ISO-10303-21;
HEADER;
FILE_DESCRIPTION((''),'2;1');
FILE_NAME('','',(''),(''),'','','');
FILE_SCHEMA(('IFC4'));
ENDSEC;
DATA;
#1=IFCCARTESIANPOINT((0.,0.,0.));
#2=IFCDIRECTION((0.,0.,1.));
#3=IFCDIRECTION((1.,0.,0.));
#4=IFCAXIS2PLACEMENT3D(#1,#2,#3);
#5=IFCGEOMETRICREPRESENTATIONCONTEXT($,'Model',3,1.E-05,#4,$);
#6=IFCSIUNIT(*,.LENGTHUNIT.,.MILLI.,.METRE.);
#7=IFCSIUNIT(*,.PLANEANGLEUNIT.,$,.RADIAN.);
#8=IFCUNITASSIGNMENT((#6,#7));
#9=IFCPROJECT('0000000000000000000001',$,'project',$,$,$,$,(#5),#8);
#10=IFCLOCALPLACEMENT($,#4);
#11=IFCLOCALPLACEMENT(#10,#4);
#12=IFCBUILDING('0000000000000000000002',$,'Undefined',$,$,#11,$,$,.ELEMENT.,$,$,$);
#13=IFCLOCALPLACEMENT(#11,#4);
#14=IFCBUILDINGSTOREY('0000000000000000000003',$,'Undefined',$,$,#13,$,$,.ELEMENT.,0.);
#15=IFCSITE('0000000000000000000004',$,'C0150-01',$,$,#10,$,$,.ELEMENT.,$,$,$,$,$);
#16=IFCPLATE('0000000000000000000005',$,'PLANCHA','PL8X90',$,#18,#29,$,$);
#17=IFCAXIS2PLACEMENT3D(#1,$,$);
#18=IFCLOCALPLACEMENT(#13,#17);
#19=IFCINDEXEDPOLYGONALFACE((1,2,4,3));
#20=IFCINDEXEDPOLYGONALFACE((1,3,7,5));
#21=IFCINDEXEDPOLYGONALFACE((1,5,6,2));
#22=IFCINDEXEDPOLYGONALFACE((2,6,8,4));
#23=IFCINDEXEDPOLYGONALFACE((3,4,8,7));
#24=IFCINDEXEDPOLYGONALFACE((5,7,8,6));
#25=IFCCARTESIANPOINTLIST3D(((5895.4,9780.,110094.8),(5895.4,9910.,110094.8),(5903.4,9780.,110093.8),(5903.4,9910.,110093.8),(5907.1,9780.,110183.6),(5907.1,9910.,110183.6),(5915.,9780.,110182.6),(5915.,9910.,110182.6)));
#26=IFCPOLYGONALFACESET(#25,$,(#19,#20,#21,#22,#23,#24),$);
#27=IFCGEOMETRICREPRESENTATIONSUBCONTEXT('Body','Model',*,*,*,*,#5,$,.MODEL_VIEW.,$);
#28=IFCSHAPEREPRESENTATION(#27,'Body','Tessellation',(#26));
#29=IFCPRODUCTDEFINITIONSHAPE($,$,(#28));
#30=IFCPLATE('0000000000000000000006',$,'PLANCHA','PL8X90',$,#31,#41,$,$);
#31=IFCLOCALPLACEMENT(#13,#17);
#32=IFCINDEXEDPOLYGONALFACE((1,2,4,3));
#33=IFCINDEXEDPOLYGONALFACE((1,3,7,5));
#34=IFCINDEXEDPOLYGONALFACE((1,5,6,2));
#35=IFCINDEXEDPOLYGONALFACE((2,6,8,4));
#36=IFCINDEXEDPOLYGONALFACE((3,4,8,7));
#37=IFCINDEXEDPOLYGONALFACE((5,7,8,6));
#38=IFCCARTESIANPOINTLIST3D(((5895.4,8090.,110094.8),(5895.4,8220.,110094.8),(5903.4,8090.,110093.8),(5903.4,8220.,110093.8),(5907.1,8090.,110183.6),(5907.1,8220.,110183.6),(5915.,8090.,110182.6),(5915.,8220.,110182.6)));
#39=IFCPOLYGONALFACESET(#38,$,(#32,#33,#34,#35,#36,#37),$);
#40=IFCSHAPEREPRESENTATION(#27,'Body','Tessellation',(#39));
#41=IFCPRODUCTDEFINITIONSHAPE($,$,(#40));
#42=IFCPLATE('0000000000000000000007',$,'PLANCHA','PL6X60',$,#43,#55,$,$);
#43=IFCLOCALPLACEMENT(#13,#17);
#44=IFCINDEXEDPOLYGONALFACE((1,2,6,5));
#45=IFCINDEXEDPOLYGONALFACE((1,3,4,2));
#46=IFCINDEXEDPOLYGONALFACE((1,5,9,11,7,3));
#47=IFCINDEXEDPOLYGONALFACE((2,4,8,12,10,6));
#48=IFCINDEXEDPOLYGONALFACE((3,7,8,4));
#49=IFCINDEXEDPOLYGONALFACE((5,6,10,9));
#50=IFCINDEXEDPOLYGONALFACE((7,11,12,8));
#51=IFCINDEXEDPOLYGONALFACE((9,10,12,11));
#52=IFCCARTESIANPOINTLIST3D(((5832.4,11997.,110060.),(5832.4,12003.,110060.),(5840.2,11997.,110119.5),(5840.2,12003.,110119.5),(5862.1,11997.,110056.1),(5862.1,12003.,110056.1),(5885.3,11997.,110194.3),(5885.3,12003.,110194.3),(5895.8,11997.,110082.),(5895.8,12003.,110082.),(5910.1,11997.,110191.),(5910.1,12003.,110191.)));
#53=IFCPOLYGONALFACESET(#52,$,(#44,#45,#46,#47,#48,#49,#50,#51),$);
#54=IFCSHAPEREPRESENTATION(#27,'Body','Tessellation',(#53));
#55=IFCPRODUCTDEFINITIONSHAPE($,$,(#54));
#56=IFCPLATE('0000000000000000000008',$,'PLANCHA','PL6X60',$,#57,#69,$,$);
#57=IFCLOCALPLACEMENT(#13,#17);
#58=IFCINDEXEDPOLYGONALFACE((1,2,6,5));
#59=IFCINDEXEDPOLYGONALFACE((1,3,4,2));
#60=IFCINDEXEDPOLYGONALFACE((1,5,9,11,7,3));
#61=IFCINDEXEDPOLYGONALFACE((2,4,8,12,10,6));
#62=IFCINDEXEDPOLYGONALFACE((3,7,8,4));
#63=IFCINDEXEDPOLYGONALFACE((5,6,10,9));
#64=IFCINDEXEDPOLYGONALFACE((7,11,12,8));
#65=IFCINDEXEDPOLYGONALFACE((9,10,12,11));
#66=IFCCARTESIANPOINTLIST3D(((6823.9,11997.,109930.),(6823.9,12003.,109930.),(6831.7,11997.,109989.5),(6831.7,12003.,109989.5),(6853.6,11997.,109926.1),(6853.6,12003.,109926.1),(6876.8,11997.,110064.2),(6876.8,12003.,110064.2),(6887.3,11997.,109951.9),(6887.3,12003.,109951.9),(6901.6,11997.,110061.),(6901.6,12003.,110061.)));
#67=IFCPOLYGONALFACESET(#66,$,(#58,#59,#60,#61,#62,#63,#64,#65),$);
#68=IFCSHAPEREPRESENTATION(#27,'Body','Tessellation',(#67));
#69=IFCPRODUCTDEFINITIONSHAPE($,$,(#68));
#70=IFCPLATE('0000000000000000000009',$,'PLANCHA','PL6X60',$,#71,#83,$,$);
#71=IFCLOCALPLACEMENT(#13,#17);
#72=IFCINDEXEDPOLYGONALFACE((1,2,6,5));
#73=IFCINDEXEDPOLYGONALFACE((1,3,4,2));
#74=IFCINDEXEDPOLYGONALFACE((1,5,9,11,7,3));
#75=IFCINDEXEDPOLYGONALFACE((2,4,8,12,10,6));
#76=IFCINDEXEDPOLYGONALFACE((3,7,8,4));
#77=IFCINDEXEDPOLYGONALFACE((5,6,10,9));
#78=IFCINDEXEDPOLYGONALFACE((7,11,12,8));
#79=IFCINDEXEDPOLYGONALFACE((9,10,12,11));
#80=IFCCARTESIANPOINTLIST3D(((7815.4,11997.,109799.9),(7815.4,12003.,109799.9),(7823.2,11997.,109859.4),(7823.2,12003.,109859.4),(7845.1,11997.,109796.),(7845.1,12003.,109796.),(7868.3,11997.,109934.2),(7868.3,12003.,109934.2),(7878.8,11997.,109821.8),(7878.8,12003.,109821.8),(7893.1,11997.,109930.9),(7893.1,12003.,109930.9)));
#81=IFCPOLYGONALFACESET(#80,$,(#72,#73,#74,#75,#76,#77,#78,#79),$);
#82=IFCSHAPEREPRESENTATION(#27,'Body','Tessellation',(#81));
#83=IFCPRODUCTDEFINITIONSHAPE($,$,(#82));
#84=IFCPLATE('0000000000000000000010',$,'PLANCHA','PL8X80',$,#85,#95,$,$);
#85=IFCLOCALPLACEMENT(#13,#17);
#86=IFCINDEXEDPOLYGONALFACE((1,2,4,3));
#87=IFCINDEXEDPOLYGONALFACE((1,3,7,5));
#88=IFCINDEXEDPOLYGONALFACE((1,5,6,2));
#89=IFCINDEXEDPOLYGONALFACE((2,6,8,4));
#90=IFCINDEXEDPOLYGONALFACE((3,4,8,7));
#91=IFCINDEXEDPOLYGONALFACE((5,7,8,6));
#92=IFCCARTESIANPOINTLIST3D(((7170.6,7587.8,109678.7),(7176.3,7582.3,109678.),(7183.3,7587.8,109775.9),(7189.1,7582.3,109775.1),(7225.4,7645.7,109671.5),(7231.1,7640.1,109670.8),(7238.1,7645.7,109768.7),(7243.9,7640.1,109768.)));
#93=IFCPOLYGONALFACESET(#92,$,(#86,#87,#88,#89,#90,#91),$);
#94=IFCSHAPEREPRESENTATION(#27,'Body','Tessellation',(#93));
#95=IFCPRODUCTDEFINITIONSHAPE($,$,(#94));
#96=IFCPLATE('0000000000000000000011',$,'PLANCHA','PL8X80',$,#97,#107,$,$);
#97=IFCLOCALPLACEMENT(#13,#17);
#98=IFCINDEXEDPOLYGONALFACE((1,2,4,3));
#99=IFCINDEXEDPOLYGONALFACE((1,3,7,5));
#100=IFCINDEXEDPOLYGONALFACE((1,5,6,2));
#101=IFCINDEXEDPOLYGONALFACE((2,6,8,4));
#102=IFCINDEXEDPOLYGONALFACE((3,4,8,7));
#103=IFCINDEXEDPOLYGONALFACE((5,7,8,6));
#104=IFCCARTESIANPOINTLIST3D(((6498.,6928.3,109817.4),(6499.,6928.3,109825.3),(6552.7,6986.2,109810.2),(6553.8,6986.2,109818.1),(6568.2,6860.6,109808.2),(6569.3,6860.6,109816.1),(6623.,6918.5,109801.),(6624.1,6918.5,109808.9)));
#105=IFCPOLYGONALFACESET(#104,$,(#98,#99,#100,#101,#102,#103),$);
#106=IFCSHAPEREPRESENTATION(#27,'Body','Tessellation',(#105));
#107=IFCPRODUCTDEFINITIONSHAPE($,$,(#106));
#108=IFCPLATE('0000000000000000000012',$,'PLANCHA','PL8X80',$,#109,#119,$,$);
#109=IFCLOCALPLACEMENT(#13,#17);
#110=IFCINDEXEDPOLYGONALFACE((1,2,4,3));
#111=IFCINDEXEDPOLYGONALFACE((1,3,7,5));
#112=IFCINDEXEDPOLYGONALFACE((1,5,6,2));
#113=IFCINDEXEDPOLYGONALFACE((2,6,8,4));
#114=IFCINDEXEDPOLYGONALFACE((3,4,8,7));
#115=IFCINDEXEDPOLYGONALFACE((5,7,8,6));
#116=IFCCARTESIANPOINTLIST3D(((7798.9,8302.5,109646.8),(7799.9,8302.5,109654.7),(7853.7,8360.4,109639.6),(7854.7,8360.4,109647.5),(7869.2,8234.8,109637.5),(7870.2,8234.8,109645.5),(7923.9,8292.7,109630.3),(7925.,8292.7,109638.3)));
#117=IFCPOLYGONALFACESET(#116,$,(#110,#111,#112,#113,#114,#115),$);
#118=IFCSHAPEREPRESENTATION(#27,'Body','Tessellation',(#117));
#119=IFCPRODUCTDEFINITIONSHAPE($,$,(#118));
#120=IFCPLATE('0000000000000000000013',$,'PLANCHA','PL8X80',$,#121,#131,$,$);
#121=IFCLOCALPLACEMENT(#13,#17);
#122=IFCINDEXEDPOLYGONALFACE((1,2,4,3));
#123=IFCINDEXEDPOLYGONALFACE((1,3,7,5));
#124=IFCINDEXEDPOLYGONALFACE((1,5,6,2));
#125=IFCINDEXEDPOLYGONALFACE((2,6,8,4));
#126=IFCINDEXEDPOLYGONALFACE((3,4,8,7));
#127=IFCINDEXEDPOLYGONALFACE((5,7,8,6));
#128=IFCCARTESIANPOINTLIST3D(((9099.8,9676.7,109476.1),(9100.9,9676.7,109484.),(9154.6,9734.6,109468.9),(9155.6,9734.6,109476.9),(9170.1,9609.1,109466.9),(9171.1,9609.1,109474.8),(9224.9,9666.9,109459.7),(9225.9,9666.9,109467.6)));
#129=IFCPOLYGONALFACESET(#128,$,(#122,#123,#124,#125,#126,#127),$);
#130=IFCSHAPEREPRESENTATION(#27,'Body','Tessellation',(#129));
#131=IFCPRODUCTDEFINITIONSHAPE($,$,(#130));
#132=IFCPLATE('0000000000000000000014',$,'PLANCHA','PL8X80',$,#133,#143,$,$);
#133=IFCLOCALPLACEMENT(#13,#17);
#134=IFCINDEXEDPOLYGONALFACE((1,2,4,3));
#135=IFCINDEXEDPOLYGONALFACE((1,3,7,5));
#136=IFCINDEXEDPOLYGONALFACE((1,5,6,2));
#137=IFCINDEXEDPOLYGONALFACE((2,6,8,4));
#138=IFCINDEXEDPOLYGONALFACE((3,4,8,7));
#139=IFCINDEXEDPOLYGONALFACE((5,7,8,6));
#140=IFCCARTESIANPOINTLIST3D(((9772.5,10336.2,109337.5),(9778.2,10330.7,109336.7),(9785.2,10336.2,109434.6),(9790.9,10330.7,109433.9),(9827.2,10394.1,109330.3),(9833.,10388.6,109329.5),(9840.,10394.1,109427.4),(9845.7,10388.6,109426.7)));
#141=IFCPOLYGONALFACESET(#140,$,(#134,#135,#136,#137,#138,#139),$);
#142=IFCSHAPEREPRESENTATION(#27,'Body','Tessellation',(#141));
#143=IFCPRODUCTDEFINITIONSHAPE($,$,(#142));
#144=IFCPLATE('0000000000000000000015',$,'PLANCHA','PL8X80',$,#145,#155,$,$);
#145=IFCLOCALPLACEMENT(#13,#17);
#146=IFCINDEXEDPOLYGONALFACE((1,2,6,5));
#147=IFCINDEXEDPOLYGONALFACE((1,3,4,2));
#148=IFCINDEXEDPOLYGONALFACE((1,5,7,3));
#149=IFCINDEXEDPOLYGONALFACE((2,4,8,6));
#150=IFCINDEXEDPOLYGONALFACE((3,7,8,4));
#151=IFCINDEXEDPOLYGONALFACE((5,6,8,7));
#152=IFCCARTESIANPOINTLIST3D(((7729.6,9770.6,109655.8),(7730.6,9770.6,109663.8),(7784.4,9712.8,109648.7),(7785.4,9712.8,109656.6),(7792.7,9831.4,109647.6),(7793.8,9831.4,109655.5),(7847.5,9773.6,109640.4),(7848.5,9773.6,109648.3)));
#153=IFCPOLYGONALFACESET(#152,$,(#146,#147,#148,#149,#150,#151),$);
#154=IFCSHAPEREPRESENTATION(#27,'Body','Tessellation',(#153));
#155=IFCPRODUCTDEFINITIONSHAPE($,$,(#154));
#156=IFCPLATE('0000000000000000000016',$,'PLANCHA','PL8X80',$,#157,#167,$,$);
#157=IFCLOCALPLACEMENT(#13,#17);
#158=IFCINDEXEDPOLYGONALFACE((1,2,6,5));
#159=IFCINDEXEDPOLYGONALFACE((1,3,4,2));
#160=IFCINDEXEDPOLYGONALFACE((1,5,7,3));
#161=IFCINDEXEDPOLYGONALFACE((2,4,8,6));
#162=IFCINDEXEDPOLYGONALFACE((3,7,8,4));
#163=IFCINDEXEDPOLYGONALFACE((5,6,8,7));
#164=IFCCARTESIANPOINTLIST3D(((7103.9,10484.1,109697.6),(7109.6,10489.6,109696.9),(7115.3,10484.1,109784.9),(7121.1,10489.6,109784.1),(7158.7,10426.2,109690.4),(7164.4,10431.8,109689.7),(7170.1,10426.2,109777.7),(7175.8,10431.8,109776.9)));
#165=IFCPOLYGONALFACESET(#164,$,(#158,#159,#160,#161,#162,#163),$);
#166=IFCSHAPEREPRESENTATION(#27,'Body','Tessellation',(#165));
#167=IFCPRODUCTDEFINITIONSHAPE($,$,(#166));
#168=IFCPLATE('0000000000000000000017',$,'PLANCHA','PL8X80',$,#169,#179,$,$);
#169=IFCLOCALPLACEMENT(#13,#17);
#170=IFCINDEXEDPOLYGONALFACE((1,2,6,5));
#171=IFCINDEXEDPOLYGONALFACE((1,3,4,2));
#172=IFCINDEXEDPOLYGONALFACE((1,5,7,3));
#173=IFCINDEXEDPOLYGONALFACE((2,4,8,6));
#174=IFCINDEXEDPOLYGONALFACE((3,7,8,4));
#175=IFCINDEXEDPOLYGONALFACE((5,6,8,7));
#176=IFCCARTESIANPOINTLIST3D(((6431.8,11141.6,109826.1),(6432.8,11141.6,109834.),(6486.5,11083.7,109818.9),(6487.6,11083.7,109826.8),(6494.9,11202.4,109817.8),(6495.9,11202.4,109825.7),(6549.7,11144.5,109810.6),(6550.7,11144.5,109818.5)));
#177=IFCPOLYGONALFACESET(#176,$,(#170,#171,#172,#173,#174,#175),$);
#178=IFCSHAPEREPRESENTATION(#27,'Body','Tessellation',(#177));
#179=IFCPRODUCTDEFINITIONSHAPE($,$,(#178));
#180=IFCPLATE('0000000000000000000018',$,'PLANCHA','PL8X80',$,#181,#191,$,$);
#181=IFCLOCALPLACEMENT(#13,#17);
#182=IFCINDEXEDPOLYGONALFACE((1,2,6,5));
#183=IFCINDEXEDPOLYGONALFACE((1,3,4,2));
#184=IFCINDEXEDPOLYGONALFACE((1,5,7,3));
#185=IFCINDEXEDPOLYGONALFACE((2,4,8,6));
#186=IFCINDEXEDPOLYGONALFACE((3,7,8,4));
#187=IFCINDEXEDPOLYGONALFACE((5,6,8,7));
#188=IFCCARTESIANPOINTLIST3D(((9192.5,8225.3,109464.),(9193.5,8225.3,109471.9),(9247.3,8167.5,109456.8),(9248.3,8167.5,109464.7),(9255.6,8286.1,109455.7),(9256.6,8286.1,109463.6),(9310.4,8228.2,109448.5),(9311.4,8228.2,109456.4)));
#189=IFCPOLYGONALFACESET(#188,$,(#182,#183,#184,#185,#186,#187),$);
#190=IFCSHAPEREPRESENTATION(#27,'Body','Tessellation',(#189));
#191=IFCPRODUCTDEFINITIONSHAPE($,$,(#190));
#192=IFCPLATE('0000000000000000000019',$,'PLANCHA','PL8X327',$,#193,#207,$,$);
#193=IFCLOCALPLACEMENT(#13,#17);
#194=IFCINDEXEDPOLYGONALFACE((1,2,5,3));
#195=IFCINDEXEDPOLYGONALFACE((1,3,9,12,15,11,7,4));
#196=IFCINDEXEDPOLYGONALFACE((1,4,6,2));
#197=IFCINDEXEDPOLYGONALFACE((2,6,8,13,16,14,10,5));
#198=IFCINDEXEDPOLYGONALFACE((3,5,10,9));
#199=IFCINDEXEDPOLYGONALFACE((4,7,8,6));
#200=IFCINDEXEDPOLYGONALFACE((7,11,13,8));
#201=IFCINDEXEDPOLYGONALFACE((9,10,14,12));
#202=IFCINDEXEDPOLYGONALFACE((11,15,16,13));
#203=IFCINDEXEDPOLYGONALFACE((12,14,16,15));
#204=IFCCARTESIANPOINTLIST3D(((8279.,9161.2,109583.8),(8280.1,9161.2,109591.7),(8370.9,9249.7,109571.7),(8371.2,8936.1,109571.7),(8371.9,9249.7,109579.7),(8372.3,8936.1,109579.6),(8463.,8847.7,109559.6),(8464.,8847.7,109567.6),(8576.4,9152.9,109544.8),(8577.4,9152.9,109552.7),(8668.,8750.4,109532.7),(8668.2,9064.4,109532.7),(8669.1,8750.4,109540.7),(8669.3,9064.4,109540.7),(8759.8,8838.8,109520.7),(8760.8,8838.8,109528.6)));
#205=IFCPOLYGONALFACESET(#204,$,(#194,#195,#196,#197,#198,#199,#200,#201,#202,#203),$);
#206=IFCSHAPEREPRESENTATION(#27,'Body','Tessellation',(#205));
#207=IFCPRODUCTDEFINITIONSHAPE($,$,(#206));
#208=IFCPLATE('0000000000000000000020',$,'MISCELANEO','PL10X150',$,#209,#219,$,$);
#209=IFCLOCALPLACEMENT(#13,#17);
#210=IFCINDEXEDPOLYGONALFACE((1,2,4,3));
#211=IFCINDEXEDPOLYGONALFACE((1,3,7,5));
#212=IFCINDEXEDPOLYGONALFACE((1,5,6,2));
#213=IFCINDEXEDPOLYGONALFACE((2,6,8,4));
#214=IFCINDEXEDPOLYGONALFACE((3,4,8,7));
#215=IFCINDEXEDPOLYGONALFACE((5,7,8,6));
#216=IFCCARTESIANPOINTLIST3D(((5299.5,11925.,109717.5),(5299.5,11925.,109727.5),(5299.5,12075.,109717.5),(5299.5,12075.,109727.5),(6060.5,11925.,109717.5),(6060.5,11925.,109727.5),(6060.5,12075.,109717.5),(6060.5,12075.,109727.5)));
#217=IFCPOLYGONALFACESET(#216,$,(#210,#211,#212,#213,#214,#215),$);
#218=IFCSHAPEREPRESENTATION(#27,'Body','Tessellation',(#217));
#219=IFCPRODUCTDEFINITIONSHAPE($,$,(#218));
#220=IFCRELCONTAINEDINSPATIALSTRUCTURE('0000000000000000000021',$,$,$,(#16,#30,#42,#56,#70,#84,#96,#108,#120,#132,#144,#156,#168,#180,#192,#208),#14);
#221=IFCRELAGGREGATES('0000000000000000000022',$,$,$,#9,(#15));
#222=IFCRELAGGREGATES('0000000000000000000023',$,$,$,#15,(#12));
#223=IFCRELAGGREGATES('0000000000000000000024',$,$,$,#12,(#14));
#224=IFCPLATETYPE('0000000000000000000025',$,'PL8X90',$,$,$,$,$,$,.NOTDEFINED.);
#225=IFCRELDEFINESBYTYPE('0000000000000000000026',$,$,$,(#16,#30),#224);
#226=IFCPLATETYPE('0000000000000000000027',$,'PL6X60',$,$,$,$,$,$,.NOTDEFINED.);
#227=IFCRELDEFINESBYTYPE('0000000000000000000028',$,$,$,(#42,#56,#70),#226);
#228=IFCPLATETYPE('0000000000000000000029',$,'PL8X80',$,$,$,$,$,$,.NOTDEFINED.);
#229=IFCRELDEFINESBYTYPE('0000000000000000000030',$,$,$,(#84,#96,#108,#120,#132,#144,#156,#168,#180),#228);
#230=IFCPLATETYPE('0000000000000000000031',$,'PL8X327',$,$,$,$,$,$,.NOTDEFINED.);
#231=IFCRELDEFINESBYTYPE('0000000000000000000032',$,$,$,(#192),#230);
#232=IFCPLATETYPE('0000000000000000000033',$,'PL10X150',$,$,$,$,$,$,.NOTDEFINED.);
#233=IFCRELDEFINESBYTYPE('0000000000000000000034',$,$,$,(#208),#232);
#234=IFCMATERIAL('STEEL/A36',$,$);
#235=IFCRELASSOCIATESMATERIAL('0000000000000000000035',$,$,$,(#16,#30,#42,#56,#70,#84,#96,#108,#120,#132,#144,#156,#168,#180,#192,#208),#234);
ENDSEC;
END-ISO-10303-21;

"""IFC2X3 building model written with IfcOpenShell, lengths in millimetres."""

from ifc_helpers import new_model, si_unit, frame, origin_with_axes, place, context, subcontext, project, spatial, polyline, outline, extrude, material, type_object, element, save


model = new_model("IFC2X3")

# Units and contexts
model_context = context("Model", 3, precision=1e-05, world=origin_with_axes())
body_context = subcontext(model_context, "Body", "Model", "MODEL_VIEW")
ifc_project = project(units=[si_unit("LENGTHUNIT", "METRE", prefix="MILLI"), si_unit("PLANEANGLEUNIT", "RADIAN")], contexts=[model_context])

# Site, building, storey
site_placement = place(None, origin_with_axes())
site = spatial("IfcSite", under=ifc_project, at=site_placement, Name="C0150-01", CompositionType="ELEMENT")
building_placement = place(site_placement, origin_with_axes())
building = spatial("IfcBuilding", under=site, at=building_placement, Name="Undefined", CompositionType="ELEMENT")
storey_placement = place(building_placement, origin_with_axes())
storey = spatial("IfcBuildingStorey", under=building, at=storey_placement, Name="Undefined", CompositionType="ELEMENT", Elevation=0.0)

# Shared definitions
ifc_material_1 = material(Name="STEEL/A36")

# Plates
plate_type_1 = type_object("IfcPlateType", Name="PL8X90", PredefinedType="NOTDEFINED")
for number, where, z_axis, x_axis, name in (
    (1, (5911.0, 9910.0, 110183.1), (0.991507, 0.0, -0.130054), (0.0, -1.0, 0.0), "PLANCHA"),
    (2, (5911.0, 8090.0, 110183.1), (-0.991507, 0.0, 0.130054), (0.0, 1.0, 0.0), "PLANCHA"),
):
    element("IfcPlate", number, at=place(storey_placement, frame(where, z_axis=z_axis, x_axis=x_axis)), inside=storey, type_object=plate_type_1, material=ifc_material_1, Name=name, Description="PL8X90", context=body_context, shape_type="SweptSolid", body=[
        extrude(outline(polyline([(0.0, 0.0), (130.0, 0.0), (130.0, 89.6), (0.0, 89.6), (0.0, 0.0)])), frame((0.0, 0.0, -4.0), z_axis=(0.0, 0.0, 1.0), x_axis=(1.0, 0.0, 0.0)), (0.0, 0.0, 1.0), 8.0),
    ])
plate_type_2 = type_object("IfcPlateType", Name="PL6X60", PredefinedType="NOTDEFINED")
for number, where, z_axis, x_axis, name in (
    (3, (5885.3, 12000.0, 110194.3), (0.0, 1.0, 0.0), (0.991507, 0.0, -0.130054), "PLANCHA"),
    (4, (6876.8, 12000.0, 110064.2), (0.0, 1.0, 0.0), (0.991507, 0.0, -0.130054), "PLANCHA"),
    (5, (7868.3, 12000.0, 109934.2), (0.0, 1.0, 0.0), (0.991507, 0.0, -0.130054), "PLANCHA"),
):
    element("IfcPlate", number, at=place(storey_placement, frame(where, z_axis=z_axis, x_axis=x_axis)), inside=storey, type_object=plate_type_2, material=ifc_material_1, Name=name, Description="PL6X60", context=body_context, shape_type="SweptSolid", body=[
        extrude(outline(polyline([(0.0, 0.0), (25.0, 0.0), (25.0, 110.0), (-5.0, 140.0), (-35.0, 140.0), (-35.0, 80.0), (0.0, 0.0)])), frame((0.0, 0.0, -3.0), z_axis=(0.0, 0.0, 1.0), x_axis=(1.0, 0.0, 0.0)), (0.0, 0.0, 1.0), 6.0),
    ])
plate_type_3 = type_object("IfcPlateType", Name="PL8X80", PredefinedType="NOTDEFINED")
for number, where, z_axis, x_axis, name in (
    (6, (7241.0, 7642.9, 109768.3), (-0.71713, 0.690563, 0.094065), (-0.130054, 0.0, -0.991507), "PLANCHA"),
    (7, (6553.3, 6986.2, 109814.2), (-0.130054, 0.0, -0.991507), (0.71713, -0.690563, -0.094065), "PLANCHA"),
    (8, (7854.2, 8360.4, 109643.5), (-0.130054, 0.0, -0.991507), (0.71713, -0.690563, -0.094065), "PLANCHA"),
    (9, (9155.1, 9734.6, 109472.9), (-0.130054, 0.0, -0.991507), (0.71713, -0.690563, -0.094065), "PLANCHA"),
    (10, (9842.8, 10391.3, 109427.1), (-0.71713, 0.690563, 0.094065), (-0.130054, 0.0, -0.991507), "PLANCHA"),
):
    element("IfcPlate", number, at=place(storey_placement, frame(where, z_axis=z_axis, x_axis=x_axis)), inside=storey, type_object=plate_type_3, material=ifc_material_1, Name=name, Description="PL8X80", context=body_context, shape_type="SweptSolid", body=[
        extrude(outline(polyline([(0.0, 0.0), (98.0, 0.0), (98.0, 80.0), (0.0, 80.0), (0.0, 0.0)])), frame((0.0, 0.0, -4.0), z_axis=(0.0, 0.0, 1.0), x_axis=(1.0, 0.0, 0.0)), (0.0, 0.0, 1.0), 8.0),
    ])
for number, where, z_axis, x_axis, name in (
    (11, (7793.2, 9831.4, 109651.5), (-0.130054, 0.0, -0.991507), (0.684698, -0.723272, -0.089811), "PLANCHA"),
    (12, (7106.7, 10486.9, 109697.2), (-0.71713, -0.690563, 0.094065), (0.684698, -0.723272, -0.089811), "PLANCHA"),
    (13, (6495.4, 11202.4, 109821.8), (-0.130054, 0.0, -0.991507), (0.684698, -0.723272, -0.089811), "PLANCHA"),
    (14, (9256.1, 8286.1, 109459.6), (-0.130054, 0.0, -0.991507), (0.684698, -0.723272, -0.089811), "PLANCHA"),
):
    element("IfcPlate", number, at=place(storey_placement, frame(where, z_axis=z_axis, x_axis=x_axis)), inside=storey, type_object=plate_type_3, material=ifc_material_1, Name=name, Description="PL8X80", context=body_context, shape_type="SweptSolid", body=[
        extrude(outline(polyline([(0.0, 0.0), (80.0, 0.0), (80.0, 88.0), (0.0, 88.0), (0.0, 0.0)])), frame((0.0, 0.0, -4.0), z_axis=(0.0, 0.0, 1.0), x_axis=(1.0, 0.0, 0.0)), (0.0, 0.0, 1.0), 8.0),
    ])
plate_type_4 = type_object("IfcPlateType", Name="PL8X327", PredefinedType="NOTDEFINED")
plate_1_placement = place(storey_placement, frame((8668.8, 9064.4, 109536.7), z_axis=(-0.130054, 0.0, -0.991507), x_axis=(0.375677, -0.925439, -0.049277)))
element("IfcPlate", 15, at=plate_1_placement, inside=storey, type_object=plate_type_4, material=ifc_material_1, Name="PLANCHA", Description="PL8X327", context=body_context, shape_type="SweptSolid", body=[
    extrude(outline(polyline([(0.0, 0.0), (243.7, 0.0), (290.5, 119.2), (122.1, 273.7), (5.2, 325.9), (-238.4, 326.6), (-285.1, 207.3), (-117.0, 52.2), (0.0, 0.0)])), frame((0.0, 0.0, -4.0), z_axis=(0.0, 0.0, 1.0), x_axis=(1.0, 0.0, 0.0)), (0.0, 0.0, 1.0), 8.0),
])
plate_type_5 = type_object("IfcPlateType", Name="PL10X150", PredefinedType="NOTDEFINED")
plate_2_placement = place(storey_placement, frame((6060.5, 11925.0, 109722.5), z_axis=(0.0, 0.0, 1.0), x_axis=(0.0, 1.0, 0.0)))
element("IfcPlate", 16, at=plate_2_placement, inside=storey, type_object=plate_type_5, material=ifc_material_1, Name="MISCELANEO", Description="PL10X150", context=body_context, shape_type="SweptSolid", body=[
    extrude(outline(polyline([(0.0, 0.0), (150.0, 0.0), (150.0, 761.1), (0.0, 761.1), (0.0, 0.0)])), frame((0.0, 0.0, -5.0), z_axis=(0.0, 0.0, 1.0), x_axis=(1.0, 0.0, 0.0)), (0.0, 0.0, 1.0), 10.0),
])

save(model, "model.ifc")
